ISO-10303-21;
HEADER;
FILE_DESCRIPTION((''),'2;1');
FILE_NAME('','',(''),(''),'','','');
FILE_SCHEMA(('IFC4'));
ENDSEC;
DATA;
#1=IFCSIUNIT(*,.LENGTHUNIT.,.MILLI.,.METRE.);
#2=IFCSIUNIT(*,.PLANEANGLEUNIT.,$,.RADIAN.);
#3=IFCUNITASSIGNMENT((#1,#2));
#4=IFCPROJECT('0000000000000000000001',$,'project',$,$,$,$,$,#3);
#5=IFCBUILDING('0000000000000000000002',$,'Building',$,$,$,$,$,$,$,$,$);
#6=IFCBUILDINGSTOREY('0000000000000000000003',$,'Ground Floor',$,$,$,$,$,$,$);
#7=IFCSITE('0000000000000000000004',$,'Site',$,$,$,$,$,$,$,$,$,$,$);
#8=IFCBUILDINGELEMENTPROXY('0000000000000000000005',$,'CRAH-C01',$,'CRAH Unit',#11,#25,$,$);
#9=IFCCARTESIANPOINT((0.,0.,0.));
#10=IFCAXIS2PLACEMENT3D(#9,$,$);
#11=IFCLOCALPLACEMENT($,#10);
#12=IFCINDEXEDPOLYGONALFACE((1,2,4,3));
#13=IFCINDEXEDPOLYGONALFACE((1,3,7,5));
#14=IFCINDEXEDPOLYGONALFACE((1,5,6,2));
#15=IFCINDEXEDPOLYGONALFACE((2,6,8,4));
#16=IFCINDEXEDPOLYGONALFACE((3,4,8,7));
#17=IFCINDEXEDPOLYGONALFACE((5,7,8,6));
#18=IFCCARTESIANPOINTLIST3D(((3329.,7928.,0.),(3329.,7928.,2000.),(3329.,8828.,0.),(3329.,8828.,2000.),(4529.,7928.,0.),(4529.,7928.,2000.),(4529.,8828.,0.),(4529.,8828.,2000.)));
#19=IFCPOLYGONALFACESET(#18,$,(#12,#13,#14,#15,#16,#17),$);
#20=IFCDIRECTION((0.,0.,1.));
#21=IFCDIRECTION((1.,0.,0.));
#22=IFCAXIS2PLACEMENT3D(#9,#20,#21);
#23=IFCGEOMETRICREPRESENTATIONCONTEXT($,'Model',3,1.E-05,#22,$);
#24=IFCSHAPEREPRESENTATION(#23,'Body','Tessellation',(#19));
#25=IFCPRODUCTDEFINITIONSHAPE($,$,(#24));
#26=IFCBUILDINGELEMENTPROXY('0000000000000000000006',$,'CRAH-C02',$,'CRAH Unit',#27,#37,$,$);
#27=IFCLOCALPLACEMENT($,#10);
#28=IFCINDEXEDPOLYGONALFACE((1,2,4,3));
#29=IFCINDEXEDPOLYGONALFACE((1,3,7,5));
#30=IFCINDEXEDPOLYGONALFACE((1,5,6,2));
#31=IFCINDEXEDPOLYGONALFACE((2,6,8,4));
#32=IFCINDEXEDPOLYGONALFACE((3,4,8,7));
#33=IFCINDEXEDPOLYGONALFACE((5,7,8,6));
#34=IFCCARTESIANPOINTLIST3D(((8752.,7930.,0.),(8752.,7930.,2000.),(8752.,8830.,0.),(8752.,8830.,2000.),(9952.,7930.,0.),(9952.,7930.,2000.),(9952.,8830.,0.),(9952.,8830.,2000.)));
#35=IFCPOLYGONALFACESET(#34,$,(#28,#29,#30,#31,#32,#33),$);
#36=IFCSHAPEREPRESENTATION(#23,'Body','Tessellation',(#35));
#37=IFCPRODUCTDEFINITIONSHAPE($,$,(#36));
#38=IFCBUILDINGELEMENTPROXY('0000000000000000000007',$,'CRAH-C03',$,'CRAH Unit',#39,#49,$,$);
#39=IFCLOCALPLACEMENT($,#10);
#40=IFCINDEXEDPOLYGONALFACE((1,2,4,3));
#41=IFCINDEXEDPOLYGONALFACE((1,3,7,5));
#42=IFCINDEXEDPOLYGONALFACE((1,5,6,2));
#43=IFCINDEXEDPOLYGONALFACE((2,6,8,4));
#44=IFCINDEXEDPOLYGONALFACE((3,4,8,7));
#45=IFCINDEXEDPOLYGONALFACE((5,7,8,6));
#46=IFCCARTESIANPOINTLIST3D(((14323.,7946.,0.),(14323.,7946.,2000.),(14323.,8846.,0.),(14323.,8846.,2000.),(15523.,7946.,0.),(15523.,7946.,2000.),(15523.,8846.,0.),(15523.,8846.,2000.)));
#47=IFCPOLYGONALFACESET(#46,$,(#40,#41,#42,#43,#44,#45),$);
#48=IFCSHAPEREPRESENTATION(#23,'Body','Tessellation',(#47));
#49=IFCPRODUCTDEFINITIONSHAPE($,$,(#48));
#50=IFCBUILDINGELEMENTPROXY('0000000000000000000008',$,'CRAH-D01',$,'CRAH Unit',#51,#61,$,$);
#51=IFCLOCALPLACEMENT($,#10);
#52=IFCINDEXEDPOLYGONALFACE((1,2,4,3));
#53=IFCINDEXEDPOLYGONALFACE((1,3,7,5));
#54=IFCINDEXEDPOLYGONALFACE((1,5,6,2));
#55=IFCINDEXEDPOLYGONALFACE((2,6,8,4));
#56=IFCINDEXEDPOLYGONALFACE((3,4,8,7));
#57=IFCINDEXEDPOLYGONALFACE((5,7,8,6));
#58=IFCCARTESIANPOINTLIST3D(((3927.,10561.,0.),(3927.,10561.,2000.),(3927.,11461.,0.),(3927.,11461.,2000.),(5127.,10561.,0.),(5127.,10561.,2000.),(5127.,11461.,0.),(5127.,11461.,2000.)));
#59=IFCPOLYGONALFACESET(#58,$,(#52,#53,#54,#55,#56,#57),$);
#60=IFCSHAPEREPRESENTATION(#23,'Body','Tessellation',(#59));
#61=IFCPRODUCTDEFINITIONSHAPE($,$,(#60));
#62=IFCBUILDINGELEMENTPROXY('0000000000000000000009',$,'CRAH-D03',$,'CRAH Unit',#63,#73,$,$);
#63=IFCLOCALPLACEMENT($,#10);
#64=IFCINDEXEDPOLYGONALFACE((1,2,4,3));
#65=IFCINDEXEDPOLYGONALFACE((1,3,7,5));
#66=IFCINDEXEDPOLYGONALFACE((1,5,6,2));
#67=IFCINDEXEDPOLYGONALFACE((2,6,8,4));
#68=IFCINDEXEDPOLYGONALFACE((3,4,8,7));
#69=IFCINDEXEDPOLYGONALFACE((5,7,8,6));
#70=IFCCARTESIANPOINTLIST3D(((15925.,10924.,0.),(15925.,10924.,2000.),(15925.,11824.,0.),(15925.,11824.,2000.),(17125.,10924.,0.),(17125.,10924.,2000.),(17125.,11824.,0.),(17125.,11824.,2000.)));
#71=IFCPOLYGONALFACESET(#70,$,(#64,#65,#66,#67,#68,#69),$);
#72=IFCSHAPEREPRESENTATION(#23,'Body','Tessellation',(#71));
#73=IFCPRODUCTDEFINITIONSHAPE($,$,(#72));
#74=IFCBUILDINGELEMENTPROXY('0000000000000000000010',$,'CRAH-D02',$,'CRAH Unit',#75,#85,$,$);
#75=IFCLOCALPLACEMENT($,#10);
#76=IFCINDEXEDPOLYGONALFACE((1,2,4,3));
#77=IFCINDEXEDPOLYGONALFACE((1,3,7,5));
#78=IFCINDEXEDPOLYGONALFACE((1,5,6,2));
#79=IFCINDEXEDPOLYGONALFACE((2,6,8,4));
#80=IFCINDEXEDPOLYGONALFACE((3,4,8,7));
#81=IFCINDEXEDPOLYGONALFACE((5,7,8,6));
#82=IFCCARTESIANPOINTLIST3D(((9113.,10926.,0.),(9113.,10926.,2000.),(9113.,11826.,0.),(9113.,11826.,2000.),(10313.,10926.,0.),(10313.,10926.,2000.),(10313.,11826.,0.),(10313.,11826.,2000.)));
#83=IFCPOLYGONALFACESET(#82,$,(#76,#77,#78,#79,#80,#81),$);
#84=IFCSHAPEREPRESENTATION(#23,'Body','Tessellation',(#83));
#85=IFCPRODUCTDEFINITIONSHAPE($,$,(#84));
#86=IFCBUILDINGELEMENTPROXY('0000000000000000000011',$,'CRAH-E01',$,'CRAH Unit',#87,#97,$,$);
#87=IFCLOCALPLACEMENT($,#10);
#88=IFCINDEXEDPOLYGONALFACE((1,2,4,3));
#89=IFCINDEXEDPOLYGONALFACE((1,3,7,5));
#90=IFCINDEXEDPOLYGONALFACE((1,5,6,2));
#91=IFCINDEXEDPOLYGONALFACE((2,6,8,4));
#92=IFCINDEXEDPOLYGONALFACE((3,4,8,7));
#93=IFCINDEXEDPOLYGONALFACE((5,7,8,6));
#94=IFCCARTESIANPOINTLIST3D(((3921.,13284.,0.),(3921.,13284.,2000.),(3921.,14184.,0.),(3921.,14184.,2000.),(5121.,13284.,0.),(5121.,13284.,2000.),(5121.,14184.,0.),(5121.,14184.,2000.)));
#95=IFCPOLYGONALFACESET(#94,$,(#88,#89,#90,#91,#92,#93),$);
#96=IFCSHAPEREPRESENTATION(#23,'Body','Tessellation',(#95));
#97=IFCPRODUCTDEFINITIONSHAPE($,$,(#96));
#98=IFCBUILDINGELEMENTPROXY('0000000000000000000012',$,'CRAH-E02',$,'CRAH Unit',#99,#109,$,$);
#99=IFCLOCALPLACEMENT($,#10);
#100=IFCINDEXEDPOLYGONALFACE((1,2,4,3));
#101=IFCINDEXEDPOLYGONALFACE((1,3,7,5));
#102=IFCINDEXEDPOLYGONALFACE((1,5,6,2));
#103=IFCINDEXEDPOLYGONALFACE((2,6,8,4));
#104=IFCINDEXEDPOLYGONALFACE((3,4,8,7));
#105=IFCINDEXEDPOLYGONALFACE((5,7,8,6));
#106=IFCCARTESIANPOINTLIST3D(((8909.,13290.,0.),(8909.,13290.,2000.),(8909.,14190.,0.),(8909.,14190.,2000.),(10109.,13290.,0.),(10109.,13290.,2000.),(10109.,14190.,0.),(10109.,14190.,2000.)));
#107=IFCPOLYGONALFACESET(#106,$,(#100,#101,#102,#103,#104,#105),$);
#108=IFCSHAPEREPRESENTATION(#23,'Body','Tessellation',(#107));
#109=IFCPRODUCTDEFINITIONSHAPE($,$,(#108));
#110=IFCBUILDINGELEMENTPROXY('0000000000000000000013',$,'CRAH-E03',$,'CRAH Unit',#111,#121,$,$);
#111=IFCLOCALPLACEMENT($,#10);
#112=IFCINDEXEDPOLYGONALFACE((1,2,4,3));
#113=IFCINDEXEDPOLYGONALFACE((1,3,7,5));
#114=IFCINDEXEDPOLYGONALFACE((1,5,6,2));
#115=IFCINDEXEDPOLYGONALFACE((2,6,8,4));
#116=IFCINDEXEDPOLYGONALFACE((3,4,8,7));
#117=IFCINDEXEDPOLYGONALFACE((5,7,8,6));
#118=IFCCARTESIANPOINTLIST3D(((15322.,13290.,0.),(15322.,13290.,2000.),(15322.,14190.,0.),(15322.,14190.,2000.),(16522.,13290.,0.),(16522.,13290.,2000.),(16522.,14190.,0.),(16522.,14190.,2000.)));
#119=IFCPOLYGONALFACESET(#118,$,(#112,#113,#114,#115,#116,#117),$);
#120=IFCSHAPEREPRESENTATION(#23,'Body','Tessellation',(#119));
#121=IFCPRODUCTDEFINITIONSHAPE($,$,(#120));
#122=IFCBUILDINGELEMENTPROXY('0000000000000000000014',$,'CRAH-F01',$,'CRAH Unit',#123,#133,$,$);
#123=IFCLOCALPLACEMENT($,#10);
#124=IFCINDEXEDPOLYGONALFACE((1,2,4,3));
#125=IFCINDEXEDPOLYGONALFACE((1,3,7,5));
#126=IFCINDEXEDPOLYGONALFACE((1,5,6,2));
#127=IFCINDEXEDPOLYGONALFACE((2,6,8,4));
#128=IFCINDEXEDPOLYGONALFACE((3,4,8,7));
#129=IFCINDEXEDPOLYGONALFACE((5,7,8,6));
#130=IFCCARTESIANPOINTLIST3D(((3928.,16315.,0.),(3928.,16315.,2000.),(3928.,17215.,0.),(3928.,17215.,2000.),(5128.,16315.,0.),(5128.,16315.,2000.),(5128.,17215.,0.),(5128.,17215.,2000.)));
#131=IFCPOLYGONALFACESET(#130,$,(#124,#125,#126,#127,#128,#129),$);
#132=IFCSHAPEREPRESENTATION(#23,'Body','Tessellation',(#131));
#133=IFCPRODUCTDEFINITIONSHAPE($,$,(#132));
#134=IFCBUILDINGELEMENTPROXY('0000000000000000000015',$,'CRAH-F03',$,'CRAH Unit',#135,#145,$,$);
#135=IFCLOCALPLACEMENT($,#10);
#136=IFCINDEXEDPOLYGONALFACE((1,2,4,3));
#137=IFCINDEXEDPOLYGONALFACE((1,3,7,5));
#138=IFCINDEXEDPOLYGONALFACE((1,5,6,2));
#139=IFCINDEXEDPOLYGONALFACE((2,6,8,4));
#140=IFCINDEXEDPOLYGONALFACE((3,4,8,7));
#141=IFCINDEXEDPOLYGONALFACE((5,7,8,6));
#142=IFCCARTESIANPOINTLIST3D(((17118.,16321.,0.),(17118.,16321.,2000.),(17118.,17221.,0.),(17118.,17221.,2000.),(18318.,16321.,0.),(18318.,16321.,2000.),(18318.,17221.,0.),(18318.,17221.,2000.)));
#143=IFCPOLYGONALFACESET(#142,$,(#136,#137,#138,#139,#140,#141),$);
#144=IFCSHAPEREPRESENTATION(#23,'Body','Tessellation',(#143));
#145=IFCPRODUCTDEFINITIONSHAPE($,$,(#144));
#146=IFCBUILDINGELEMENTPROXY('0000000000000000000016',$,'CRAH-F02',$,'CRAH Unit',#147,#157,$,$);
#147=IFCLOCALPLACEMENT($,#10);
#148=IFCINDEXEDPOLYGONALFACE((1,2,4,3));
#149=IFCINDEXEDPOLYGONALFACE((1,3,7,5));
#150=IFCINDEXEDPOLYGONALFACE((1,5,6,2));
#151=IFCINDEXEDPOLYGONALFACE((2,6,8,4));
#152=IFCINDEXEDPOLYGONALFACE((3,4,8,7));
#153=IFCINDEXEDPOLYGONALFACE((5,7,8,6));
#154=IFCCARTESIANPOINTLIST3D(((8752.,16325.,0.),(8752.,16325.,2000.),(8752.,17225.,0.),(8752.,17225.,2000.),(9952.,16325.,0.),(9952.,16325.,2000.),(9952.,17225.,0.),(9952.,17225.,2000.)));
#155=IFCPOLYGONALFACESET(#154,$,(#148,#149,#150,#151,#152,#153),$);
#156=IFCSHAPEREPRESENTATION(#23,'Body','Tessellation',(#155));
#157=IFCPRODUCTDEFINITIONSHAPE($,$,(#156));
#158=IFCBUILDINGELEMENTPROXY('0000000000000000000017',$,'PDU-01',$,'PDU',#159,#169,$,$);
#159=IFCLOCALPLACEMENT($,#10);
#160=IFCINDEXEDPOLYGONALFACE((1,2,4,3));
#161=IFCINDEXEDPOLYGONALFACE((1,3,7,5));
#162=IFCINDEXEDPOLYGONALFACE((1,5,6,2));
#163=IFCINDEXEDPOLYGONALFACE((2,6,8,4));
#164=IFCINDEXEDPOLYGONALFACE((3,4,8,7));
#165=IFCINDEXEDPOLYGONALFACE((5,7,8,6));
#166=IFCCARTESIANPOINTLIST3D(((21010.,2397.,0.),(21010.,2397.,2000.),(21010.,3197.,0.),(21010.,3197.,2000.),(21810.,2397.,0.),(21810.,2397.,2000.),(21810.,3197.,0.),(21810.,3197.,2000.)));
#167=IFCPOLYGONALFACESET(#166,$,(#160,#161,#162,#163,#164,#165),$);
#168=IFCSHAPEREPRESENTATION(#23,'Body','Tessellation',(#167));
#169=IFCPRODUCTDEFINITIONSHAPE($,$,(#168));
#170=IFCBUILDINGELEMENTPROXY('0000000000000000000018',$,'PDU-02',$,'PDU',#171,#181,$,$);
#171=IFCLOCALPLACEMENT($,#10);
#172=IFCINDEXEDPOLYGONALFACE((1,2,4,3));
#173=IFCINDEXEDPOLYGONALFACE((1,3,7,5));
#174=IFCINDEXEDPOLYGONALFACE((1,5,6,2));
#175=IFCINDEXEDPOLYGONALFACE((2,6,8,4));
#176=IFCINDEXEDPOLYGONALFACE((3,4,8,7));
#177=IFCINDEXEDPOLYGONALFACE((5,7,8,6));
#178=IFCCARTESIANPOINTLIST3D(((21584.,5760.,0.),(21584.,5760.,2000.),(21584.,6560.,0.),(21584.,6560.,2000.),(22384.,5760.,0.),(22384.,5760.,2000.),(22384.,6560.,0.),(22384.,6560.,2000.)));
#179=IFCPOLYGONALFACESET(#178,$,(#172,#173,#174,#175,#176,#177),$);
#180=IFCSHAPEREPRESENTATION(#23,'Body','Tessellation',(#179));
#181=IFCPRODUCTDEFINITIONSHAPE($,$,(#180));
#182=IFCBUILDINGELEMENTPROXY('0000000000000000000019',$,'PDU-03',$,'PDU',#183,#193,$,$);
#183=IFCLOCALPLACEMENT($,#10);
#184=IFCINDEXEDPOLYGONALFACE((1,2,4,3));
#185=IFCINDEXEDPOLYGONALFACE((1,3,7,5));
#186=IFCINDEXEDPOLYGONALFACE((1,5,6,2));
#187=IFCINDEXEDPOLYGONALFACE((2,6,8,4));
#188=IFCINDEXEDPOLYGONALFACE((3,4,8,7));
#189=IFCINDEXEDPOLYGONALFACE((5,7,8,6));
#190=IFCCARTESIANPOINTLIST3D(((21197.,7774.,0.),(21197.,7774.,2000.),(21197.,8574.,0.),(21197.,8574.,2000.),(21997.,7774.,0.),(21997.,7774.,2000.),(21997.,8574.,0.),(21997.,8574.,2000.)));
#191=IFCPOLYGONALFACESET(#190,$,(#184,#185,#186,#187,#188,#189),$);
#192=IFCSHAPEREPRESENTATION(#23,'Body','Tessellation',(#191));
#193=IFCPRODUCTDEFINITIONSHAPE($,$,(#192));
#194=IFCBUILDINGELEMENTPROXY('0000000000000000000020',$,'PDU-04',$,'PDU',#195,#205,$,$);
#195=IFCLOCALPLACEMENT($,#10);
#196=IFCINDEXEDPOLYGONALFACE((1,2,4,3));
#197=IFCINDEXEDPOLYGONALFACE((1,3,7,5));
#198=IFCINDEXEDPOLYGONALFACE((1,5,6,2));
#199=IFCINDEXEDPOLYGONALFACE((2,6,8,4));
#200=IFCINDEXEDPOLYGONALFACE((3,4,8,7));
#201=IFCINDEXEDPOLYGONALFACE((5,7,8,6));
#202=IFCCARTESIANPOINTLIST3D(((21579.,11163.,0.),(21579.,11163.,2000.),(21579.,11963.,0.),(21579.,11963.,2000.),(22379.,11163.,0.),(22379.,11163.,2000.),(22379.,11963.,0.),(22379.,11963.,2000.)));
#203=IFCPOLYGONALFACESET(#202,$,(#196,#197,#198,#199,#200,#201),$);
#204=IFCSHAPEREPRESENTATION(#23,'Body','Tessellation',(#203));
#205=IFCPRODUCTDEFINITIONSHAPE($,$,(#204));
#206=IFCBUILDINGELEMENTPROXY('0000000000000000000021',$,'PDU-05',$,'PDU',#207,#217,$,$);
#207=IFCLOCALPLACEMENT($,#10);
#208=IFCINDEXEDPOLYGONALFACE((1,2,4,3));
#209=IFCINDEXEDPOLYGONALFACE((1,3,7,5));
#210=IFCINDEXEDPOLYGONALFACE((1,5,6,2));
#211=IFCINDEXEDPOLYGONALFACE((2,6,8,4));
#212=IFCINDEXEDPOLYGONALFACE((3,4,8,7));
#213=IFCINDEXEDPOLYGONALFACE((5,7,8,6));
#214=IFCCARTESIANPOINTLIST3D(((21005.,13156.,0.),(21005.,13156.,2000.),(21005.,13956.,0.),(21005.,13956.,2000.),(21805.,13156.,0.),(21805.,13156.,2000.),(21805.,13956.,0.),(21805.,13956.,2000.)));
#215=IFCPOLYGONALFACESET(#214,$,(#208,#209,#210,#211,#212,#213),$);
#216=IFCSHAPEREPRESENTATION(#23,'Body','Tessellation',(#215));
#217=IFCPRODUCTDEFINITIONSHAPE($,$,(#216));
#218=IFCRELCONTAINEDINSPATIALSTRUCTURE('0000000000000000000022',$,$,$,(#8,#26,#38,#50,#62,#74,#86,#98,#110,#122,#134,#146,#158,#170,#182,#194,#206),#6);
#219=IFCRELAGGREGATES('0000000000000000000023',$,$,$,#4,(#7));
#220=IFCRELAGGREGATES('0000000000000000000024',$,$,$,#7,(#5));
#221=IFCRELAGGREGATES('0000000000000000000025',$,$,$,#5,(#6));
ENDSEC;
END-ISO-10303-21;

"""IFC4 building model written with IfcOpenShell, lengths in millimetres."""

from ifc_helpers import new_model, si_unit, frame, origin_with_axes, place, context, project, spatial, rectangle, extrude, element, save


model = new_model("IFC4")

# Units and contexts
model_context = context("Model", 3, precision=1e-05, world=origin_with_axes())
ifc_project = project(units=[si_unit("LENGTHUNIT", "METRE", prefix="MILLI"), si_unit("PLANEANGLEUNIT", "RADIAN")])

# Site, building, storey
site = spatial("IfcSite", under=ifc_project, Name="Site")
building = spatial("IfcBuilding", under=site, Name="Building")
storey = spatial("IfcBuildingStorey", under=building, Name="Ground Floor")

# Building element proxies
proxy_1_placement = place(None, origin_with_axes())
element("IfcBuildingElementProxy", 1, at=proxy_1_placement, inside=storey, Name="CRAH-C01", ObjectType="CRAH Unit", context=model_context, shape_type="SweptSolid", body=[
    extrude(rectangle(XDim=1200.0, YDim=900.0), frame((3929.0, 8378.0, 0.0), z_axis=(0.0, 0.0, 1.0), x_axis=(1.0, 0.0, 0.0)), (0.0, 0.0, 1.0), 2000.0),
])
proxy_2_placement = place(None, origin_with_axes())
element("IfcBuildingElementProxy", 2, at=proxy_2_placement, inside=storey, Name="CRAH-C02", ObjectType="CRAH Unit", context=model_context, shape_type="SweptSolid", body=[
    extrude(rectangle(XDim=1200.0, YDim=900.0), frame((9352.0, 8380.0, 0.0), z_axis=(0.0, 0.0, 1.0), x_axis=(1.0, 0.0, 0.0)), (0.0, 0.0, 1.0), 2000.0),
])
proxy_3_placement = place(None, origin_with_axes())
element("IfcBuildingElementProxy", 3, at=proxy_3_placement, inside=storey, Name="CRAH-C03", ObjectType="CRAH Unit", context=model_context, shape_type="SweptSolid", body=[
    extrude(rectangle(XDim=1200.0, YDim=900.0), frame((14923.0, 8396.0, 0.0), z_axis=(0.0, 0.0, 1.0), x_axis=(1.0, 0.0, 0.0)), (0.0, 0.0, 1.0), 2000.0),
])
proxy_4_placement = place(None, origin_with_axes())
element("IfcBuildingElementProxy", 4, at=proxy_4_placement, inside=storey, Name="CRAH-D01", ObjectType="CRAH Unit", context=model_context, shape_type="SweptSolid", body=[
    extrude(rectangle(XDim=1200.0, YDim=900.0), frame((4527.0, 11011.0, 0.0), z_axis=(0.0, 0.0, 1.0), x_axis=(1.0, 0.0, 0.0)), (0.0, 0.0, 1.0), 2000.0),
])
proxy_5_placement = place(None, origin_with_axes())
element("IfcBuildingElementProxy", 5, at=proxy_5_placement, inside=storey, Name="CRAH-D03", ObjectType="CRAH Unit", context=model_context, shape_type="SweptSolid", body=[
    extrude(rectangle(XDim=1200.0, YDim=900.0), frame((16525.0, 11374.0, 0.0), z_axis=(0.0, 0.0, 1.0), x_axis=(1.0, 0.0, 0.0)), (0.0, 0.0, 1.0), 2000.0),
])
proxy_6_placement = place(None, origin_with_axes())
element("IfcBuildingElementProxy", 6, at=proxy_6_placement, inside=storey, Name="CRAH-D02", ObjectType="CRAH Unit", context=model_context, shape_type="SweptSolid", body=[
    extrude(rectangle(XDim=1200.0, YDim=900.0), frame((9713.0, 11376.0, 0.0), z_axis=(0.0, 0.0, 1.0), x_axis=(1.0, 0.0, 0.0)), (0.0, 0.0, 1.0), 2000.0),
])
proxy_7_placement = place(None, origin_with_axes())
element("IfcBuildingElementProxy", 7, at=proxy_7_placement, inside=storey, Name="CRAH-E01", ObjectType="CRAH Unit", context=model_context, shape_type="SweptSolid", body=[
    extrude(rectangle(XDim=1200.0, YDim=900.0), frame((4521.0, 13734.0, 0.0), z_axis=(0.0, 0.0, 1.0), x_axis=(1.0, 0.0, 0.0)), (0.0, 0.0, 1.0), 2000.0),
])
proxy_8_placement = place(None, origin_with_axes())
element("IfcBuildingElementProxy", 8, at=proxy_8_placement, inside=storey, Name="CRAH-E02", ObjectType="CRAH Unit", context=model_context, shape_type="SweptSolid", body=[
    extrude(rectangle(XDim=1200.0, YDim=900.0), frame((9509.0, 13740.0, 0.0), z_axis=(0.0, 0.0, 1.0), x_axis=(1.0, 0.0, 0.0)), (0.0, 0.0, 1.0), 2000.0),
])
proxy_9_placement = place(None, origin_with_axes())
element("IfcBuildingElementProxy", 9, at=proxy_9_placement, inside=storey, Name="CRAH-E03", ObjectType="CRAH Unit", context=model_context, shape_type="SweptSolid", body=[
    extrude(rectangle(XDim=1200.0, YDim=900.0), frame((15922.0, 13740.0, 0.0), z_axis=(0.0, 0.0, 1.0), x_axis=(1.0, 0.0, 0.0)), (0.0, 0.0, 1.0), 2000.0),
])
proxy_10_placement = place(None, origin_with_axes())
element("IfcBuildingElementProxy", 10, at=proxy_10_placement, inside=storey, Name="CRAH-F01", ObjectType="CRAH Unit", context=model_context, shape_type="SweptSolid", body=[
    extrude(rectangle(XDim=1200.0, YDim=900.0), frame((4528.0, 16765.0, 0.0), z_axis=(0.0, 0.0, 1.0), x_axis=(1.0, 0.0, 0.0)), (0.0, 0.0, 1.0), 2000.0),
])
proxy_11_placement = place(None, origin_with_axes())
element("IfcBuildingElementProxy", 11, at=proxy_11_placement, inside=storey, Name="CRAH-F03", ObjectType="CRAH Unit", context=model_context, shape_type="SweptSolid", body=[
    extrude(rectangle(XDim=1200.0, YDim=900.0), frame((17718.0, 16771.0, 0.0), z_axis=(0.0, 0.0, 1.0), x_axis=(1.0, 0.0, 0.0)), (0.0, 0.0, 1.0), 2000.0),
])
proxy_12_placement = place(None, origin_with_axes())
element("IfcBuildingElementProxy", 12, at=proxy_12_placement, inside=storey, Name="CRAH-F02", ObjectType="CRAH Unit", context=model_context, shape_type="SweptSolid", body=[
    extrude(rectangle(XDim=1200.0, YDim=900.0), frame((9352.0, 16775.0, 0.0), z_axis=(0.0, 0.0, 1.0), x_axis=(1.0, 0.0, 0.0)), (0.0, 0.0, 1.0), 2000.0),
])
proxy_13_placement = place(None, origin_with_axes())
element("IfcBuildingElementProxy", 13, at=proxy_13_placement, inside=storey, Name="PDU-01", ObjectType="PDU", context=model_context, shape_type="SweptSolid", body=[
    extrude(rectangle(XDim=800.0, YDim=800.0), frame((21410.0, 2797.0, 0.0), z_axis=(0.0, 0.0, 1.0), x_axis=(1.0, 0.0, 0.0)), (0.0, 0.0, 1.0), 2000.0),
])
proxy_14_placement = place(None, origin_with_axes())
element("IfcBuildingElementProxy", 14, at=proxy_14_placement, inside=storey, Name="PDU-02", ObjectType="PDU", context=model_context, shape_type="SweptSolid", body=[
    extrude(rectangle(XDim=800.0, YDim=800.0), frame((21984.0, 6160.0, 0.0), z_axis=(0.0, 0.0, 1.0), x_axis=(1.0, 0.0, 0.0)), (0.0, 0.0, 1.0), 2000.0),
])
proxy_15_placement = place(None, origin_with_axes())
element("IfcBuildingElementProxy", 15, at=proxy_15_placement, inside=storey, Name="PDU-03", ObjectType="PDU", context=model_context, shape_type="SweptSolid", body=[
    extrude(rectangle(XDim=800.0, YDim=800.0), frame((21597.0, 8174.0, 0.0), z_axis=(0.0, 0.0, 1.0), x_axis=(1.0, 0.0, 0.0)), (0.0, 0.0, 1.0), 2000.0),
])
proxy_16_placement = place(None, origin_with_axes())
element("IfcBuildingElementProxy", 16, at=proxy_16_placement, inside=storey, Name="PDU-04", ObjectType="PDU", context=model_context, shape_type="SweptSolid", body=[
    extrude(rectangle(XDim=800.0, YDim=800.0), frame((21979.0, 11563.0, 0.0), z_axis=(0.0, 0.0, 1.0), x_axis=(1.0, 0.0, 0.0)), (0.0, 0.0, 1.0), 2000.0),
])
proxy_17_placement = place(None, origin_with_axes())
element("IfcBuildingElementProxy", 17, at=proxy_17_placement, inside=storey, Name="PDU-05", ObjectType="PDU", context=model_context, shape_type="SweptSolid", body=[
    extrude(rectangle(XDim=800.0, YDim=800.0), frame((21405.0, 13556.0, 0.0), z_axis=(0.0, 0.0, 1.0), x_axis=(1.0, 0.0, 0.0)), (0.0, 0.0, 1.0), 2000.0),
])

save(model, "model.ifc")
